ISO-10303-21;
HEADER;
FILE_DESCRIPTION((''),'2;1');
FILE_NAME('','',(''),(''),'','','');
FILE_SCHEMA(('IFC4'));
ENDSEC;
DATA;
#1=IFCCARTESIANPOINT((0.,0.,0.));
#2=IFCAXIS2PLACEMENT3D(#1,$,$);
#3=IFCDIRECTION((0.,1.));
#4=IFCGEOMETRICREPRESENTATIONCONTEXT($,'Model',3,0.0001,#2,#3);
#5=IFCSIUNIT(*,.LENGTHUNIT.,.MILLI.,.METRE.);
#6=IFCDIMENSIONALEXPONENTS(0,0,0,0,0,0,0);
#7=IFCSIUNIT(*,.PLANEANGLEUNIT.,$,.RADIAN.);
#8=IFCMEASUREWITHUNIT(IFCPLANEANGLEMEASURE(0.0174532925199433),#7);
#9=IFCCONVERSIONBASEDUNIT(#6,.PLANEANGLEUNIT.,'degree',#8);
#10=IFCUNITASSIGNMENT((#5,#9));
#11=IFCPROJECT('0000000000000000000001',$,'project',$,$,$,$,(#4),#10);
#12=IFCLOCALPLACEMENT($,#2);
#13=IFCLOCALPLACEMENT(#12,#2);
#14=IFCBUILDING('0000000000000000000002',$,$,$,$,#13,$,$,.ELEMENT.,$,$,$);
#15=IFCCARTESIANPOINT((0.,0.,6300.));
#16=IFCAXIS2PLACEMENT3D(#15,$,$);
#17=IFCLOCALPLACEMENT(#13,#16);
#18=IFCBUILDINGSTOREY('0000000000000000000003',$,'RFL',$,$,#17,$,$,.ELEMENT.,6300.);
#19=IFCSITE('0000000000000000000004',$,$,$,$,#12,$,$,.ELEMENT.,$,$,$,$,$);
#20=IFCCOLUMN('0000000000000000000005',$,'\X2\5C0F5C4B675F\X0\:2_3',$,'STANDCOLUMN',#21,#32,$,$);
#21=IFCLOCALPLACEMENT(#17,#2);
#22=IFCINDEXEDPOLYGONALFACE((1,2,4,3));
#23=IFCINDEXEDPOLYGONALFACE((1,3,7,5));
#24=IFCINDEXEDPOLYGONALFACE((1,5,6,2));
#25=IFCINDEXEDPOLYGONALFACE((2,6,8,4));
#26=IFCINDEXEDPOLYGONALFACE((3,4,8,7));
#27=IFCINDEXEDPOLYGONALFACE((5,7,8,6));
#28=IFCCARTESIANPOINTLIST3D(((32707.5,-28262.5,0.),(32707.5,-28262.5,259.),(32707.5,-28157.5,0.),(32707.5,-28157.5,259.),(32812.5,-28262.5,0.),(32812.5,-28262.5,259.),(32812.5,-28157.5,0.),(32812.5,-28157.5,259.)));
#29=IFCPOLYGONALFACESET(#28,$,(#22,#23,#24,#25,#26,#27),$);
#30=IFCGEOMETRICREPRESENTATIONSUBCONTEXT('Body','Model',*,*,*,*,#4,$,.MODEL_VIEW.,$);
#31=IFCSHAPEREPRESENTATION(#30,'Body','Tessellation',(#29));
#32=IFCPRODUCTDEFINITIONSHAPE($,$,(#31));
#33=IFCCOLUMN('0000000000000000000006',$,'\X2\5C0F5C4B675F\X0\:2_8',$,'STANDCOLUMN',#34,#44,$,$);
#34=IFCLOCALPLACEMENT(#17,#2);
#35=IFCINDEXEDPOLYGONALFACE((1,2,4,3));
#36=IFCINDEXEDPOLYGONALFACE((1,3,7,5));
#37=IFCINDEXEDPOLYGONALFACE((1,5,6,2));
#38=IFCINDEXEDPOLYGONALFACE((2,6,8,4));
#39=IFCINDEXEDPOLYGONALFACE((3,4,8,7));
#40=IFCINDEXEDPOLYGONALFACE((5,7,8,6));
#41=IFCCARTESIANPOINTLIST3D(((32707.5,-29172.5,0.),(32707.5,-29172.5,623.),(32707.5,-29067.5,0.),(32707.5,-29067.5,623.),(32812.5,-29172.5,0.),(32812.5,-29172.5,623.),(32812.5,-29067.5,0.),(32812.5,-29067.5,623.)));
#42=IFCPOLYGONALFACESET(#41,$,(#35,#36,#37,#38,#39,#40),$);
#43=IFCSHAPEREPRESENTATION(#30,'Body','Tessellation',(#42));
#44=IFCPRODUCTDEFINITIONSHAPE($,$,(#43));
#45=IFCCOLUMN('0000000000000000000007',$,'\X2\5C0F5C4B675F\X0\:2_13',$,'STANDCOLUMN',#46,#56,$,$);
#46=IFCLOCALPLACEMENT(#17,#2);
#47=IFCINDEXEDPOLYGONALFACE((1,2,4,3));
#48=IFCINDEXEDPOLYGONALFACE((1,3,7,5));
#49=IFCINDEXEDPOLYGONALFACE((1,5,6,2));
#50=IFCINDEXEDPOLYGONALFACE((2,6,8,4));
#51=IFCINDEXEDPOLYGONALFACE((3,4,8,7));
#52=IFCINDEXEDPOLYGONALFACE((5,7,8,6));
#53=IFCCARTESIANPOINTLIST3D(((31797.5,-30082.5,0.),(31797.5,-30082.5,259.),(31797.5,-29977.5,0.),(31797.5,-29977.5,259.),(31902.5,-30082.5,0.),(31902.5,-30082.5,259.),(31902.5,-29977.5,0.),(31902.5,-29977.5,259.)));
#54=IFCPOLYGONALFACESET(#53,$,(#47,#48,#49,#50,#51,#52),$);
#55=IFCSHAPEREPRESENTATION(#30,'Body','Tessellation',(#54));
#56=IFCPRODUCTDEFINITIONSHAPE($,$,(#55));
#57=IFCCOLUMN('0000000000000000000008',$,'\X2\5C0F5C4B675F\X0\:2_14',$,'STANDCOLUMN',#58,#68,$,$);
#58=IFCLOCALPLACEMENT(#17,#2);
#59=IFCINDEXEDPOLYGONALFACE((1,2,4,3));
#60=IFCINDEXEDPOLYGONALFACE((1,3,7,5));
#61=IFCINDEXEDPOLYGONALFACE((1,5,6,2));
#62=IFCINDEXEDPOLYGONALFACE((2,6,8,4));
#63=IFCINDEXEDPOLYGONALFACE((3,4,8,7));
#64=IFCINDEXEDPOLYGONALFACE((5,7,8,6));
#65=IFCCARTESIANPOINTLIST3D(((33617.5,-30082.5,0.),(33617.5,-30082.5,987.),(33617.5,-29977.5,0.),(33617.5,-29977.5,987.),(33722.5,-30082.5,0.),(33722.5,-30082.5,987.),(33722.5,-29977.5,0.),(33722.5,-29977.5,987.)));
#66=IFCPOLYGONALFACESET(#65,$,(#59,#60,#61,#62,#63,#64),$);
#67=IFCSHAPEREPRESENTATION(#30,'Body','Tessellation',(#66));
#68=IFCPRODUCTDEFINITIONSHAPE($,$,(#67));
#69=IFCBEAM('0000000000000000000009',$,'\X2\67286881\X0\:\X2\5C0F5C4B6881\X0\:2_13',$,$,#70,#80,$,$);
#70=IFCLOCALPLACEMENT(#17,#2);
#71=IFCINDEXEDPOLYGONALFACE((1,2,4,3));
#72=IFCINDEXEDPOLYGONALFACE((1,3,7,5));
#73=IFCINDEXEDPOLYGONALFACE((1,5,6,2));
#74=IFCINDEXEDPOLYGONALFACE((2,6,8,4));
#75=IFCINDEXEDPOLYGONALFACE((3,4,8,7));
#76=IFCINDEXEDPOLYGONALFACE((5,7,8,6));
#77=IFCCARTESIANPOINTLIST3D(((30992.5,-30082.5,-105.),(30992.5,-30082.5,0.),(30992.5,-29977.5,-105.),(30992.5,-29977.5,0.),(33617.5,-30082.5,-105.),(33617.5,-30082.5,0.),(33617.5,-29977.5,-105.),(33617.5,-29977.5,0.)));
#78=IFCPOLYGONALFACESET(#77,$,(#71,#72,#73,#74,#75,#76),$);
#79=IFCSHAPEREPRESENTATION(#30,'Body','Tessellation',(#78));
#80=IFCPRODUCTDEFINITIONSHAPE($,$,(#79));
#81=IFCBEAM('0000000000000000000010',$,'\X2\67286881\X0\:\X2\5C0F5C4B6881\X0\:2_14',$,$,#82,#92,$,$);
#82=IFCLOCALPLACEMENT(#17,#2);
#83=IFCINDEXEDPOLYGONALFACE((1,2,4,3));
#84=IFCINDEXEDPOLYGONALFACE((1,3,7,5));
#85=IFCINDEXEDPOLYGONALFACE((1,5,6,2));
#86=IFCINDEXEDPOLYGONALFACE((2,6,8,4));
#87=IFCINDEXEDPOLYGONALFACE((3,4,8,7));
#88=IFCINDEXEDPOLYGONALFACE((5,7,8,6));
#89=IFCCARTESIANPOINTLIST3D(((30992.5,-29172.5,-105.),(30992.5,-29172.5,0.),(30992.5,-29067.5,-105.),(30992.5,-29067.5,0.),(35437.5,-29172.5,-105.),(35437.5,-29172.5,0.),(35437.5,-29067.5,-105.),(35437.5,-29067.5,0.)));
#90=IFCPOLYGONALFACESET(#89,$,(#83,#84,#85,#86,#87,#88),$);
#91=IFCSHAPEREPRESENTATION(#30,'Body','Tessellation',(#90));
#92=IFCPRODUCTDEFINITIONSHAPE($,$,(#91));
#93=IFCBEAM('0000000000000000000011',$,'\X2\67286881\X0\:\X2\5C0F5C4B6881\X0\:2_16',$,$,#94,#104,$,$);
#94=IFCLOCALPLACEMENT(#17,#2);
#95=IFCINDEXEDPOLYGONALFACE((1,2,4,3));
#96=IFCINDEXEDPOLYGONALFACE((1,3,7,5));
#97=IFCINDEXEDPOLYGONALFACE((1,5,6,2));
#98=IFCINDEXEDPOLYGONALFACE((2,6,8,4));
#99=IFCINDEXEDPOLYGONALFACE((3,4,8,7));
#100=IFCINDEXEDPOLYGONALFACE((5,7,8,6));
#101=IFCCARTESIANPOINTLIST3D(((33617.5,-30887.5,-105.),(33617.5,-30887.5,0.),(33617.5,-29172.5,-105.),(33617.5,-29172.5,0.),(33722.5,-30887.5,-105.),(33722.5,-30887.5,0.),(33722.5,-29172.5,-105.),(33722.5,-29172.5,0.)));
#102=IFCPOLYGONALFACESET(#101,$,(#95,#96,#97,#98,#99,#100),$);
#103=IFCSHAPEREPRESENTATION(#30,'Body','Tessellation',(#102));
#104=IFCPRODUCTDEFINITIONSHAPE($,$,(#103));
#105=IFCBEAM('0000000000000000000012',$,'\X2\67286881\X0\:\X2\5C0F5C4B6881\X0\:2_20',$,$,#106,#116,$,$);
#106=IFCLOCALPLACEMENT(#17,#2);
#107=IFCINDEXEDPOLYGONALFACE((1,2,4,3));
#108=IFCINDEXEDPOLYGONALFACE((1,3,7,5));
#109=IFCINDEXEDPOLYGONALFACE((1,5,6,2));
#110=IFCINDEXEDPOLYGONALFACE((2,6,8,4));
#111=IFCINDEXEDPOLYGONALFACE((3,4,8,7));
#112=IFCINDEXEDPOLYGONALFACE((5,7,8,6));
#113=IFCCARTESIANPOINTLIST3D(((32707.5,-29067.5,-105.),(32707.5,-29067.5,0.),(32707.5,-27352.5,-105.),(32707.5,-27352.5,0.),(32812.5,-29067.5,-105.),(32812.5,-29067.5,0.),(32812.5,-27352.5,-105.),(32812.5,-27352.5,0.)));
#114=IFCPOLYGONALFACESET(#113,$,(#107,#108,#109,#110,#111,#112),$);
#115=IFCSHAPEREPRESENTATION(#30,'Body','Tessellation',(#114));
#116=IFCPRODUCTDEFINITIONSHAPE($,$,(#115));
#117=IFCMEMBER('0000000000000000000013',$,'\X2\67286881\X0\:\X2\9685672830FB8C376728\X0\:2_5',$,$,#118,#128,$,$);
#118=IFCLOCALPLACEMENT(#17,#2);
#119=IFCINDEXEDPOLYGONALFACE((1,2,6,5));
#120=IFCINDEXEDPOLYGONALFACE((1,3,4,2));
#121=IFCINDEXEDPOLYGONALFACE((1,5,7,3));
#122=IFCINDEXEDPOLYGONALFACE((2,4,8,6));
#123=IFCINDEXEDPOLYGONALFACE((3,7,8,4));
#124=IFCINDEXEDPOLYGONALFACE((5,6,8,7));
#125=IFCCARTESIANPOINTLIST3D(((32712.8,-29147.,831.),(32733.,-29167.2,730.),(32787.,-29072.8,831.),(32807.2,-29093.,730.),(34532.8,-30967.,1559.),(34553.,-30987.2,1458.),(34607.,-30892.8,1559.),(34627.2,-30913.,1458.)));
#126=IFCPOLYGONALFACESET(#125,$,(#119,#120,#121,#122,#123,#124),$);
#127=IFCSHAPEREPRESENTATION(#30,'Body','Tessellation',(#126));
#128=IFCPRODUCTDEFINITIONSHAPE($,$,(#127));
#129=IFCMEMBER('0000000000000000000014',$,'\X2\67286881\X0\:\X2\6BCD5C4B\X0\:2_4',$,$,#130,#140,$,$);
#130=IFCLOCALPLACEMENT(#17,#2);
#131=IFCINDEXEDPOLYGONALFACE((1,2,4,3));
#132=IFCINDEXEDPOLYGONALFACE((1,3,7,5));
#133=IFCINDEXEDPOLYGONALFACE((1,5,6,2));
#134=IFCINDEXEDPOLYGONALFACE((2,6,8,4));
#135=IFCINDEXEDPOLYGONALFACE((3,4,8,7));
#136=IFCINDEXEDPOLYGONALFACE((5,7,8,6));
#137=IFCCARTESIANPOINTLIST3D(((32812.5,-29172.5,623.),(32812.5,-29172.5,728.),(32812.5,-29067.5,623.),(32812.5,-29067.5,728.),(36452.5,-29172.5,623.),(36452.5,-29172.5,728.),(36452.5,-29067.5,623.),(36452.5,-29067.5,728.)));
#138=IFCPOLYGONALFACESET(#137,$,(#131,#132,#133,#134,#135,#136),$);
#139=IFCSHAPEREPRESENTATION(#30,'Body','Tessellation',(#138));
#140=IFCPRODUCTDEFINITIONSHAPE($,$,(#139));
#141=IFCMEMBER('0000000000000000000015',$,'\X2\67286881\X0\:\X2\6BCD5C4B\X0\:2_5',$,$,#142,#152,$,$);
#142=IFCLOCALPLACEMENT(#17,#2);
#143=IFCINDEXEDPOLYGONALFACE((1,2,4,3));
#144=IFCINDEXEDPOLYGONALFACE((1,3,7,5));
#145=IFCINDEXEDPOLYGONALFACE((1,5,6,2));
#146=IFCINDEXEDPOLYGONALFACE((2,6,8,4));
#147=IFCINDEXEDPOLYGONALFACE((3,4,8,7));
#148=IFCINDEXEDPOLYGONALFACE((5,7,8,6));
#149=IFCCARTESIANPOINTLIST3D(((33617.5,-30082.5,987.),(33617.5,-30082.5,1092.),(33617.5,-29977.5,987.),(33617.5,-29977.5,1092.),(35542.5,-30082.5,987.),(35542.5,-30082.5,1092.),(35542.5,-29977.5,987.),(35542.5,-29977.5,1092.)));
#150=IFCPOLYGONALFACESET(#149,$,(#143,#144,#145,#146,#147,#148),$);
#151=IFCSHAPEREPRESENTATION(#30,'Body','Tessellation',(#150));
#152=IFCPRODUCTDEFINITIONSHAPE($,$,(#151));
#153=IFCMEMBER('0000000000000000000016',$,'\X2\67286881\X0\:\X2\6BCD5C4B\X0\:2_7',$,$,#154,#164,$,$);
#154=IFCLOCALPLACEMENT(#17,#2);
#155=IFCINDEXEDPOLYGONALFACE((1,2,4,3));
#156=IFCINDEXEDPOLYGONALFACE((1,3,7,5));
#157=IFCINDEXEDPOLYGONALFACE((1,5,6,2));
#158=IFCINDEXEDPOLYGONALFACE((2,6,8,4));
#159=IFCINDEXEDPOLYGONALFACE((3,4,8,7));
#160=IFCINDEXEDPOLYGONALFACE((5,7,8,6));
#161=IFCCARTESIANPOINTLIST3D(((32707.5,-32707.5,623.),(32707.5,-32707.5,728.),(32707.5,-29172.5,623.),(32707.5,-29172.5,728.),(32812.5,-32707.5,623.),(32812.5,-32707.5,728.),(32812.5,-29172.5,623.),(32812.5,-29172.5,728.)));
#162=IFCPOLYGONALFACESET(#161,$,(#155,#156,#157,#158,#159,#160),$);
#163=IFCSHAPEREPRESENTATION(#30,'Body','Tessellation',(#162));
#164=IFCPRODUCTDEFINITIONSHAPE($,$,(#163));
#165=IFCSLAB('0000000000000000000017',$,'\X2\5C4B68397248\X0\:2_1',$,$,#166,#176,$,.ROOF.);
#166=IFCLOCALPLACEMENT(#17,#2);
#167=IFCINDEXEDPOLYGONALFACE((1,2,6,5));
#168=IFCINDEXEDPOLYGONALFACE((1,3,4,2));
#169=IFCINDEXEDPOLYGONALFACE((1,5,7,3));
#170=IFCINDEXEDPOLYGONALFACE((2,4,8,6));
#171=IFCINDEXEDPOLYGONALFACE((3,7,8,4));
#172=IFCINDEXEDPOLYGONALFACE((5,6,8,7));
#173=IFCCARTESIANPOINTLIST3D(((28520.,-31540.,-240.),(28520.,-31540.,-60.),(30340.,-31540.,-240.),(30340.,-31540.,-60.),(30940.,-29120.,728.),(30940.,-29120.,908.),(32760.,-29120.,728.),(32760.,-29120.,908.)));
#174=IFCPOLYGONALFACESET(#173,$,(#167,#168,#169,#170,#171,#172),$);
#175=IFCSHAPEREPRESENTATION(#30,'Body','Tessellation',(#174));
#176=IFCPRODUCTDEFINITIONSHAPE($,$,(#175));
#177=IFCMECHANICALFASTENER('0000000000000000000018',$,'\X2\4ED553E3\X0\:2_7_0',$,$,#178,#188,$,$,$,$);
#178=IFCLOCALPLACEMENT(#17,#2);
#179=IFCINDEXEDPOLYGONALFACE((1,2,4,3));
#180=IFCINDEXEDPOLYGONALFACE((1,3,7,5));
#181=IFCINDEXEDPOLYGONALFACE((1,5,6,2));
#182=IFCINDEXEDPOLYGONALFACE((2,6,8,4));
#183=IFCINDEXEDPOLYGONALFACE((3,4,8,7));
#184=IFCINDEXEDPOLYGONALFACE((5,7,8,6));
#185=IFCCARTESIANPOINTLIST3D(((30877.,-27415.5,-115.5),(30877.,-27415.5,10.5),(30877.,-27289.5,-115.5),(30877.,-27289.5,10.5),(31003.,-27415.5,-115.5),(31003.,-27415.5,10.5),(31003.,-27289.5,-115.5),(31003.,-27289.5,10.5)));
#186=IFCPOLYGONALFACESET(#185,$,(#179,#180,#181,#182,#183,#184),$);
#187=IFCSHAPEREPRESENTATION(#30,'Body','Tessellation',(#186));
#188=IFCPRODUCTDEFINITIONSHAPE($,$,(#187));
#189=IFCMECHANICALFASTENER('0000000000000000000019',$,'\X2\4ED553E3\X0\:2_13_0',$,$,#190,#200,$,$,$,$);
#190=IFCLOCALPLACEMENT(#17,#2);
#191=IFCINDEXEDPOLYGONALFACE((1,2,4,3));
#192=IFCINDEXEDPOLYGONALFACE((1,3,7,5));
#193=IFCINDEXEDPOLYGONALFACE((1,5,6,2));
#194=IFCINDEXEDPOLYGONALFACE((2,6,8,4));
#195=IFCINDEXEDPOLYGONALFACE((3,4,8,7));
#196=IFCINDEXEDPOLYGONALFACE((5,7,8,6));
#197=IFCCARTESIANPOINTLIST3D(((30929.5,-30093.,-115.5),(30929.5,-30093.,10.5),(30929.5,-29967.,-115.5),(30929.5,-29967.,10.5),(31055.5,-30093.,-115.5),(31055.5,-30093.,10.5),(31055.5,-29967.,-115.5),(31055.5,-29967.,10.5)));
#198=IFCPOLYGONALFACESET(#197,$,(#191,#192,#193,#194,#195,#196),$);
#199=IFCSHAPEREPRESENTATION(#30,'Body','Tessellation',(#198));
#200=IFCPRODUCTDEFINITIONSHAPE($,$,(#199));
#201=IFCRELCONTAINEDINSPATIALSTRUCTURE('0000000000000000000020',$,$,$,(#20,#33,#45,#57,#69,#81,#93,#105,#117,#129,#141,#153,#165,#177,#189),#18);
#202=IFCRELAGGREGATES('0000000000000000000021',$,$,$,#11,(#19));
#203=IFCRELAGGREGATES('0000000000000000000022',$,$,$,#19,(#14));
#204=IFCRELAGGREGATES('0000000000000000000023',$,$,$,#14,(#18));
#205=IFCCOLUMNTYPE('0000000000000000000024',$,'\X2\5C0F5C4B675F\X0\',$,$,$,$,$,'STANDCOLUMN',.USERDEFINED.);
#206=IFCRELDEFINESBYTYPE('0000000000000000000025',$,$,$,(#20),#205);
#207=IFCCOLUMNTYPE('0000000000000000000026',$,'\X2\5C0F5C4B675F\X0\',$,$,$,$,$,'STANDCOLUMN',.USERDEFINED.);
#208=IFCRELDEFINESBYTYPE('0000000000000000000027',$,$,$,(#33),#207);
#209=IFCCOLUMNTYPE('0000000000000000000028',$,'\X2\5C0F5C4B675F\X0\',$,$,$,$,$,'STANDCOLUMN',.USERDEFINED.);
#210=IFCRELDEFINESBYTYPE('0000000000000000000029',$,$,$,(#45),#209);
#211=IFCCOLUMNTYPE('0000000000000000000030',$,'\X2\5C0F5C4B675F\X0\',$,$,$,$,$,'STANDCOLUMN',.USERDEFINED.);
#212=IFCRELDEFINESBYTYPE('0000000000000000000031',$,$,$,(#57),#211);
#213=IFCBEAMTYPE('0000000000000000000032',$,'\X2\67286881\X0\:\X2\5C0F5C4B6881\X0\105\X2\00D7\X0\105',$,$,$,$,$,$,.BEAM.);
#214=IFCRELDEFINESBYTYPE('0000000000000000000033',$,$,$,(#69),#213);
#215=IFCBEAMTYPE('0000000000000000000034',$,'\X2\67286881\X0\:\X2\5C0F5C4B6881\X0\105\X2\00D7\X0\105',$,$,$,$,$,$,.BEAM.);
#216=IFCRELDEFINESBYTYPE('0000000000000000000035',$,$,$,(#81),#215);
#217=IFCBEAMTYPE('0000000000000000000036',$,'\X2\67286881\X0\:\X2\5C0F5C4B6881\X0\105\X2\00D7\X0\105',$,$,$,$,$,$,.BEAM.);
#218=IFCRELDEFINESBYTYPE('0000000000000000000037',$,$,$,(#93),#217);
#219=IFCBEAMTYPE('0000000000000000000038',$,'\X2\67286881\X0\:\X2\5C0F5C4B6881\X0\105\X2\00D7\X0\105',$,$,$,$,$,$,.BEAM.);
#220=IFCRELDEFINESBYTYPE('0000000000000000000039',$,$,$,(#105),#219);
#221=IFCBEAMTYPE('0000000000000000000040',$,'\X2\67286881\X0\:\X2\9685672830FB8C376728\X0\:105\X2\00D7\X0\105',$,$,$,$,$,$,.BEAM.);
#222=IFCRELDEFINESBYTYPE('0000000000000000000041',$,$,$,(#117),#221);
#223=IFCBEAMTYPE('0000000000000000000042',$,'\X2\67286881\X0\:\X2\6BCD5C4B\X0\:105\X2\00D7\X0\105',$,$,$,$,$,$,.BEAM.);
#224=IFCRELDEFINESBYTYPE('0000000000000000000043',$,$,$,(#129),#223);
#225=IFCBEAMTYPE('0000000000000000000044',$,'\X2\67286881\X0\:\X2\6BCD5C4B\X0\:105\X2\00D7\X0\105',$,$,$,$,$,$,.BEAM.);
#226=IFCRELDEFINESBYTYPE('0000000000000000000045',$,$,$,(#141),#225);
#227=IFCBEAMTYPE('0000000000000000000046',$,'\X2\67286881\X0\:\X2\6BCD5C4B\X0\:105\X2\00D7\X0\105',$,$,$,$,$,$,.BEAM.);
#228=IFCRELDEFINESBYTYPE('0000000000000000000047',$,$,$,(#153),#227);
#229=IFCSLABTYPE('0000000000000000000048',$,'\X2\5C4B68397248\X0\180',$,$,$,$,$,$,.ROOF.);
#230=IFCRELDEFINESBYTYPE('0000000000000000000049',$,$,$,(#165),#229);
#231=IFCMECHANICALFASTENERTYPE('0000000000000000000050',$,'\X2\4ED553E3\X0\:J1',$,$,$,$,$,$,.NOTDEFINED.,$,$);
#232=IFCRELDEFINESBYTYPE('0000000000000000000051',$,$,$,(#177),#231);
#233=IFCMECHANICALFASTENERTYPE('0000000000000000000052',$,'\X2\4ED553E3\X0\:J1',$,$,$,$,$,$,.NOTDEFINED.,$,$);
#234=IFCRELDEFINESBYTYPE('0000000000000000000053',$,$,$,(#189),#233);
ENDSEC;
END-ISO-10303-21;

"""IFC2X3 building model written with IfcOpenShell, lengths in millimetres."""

from ifc_helpers import new_model, entity, si_unit, converted_unit, direction, frame, origin, origin_with_axes, origin_2d, place, context, subcontext, project, spatial, polyline, rectangle, outline, extrude, type_object, element, save


model = new_model("IFC2X3")

# Units and contexts
model_context = context("Model", 3, precision=0.0001, world=origin(), true_north=direction((0.0, 1.0)))
body_context = subcontext(model_context, "Body", "Model", "MODEL_VIEW")
ifc_project = project(units=[si_unit("LENGTHUNIT", "METRE", prefix="MILLI"), converted_unit("PLANEANGLEUNIT", "degree", entity("IfcPlaneAngleMeasure", 0.0174532925199433), si_unit("PLANEANGLEUNIT", "RADIAN"), dimensions=[0, 0, 0, 0, 0, 0, 0])], contexts=[model_context])

# Site, building, storey
site_placement = place(None, origin())
site = spatial("IfcSite", under=ifc_project, at=site_placement, CompositionType="ELEMENT")
building_placement = place(site_placement, origin())
building = spatial("IfcBuilding", under=site, at=building_placement, CompositionType="ELEMENT")
storey_placement = place(building_placement, frame((0.0, 0.0, 6300.0)))
storey = spatial("IfcBuildingStorey", under=building, at=storey_placement, Name="RFL", CompositionType="ELEMENT", Elevation=6300.0)

# Columns
column_type_1 = type_object("IfcColumnType", Name="小屋束", ElementType="STANDCOLUMN", PredefinedType="USERDEFINED")
column_1_placement = place(storey_placement, frame((32760.0, -28210.0, 0.0)))
element("IfcColumn", 1, at=column_1_placement, inside=storey, type_object=column_type_1, Name="小屋束:2_3", ObjectType="STANDCOLUMN", context=body_context, shape_type="SweptSolid", body=[
    extrude(rectangle(XDim=105.0, YDim=105.0, at=origin_2d()), origin_with_axes(), (0.0, 0.0, 1.0), 259.0),
])
column_type_2 = type_object("IfcColumnType", Name="小屋束", ElementType="STANDCOLUMN", PredefinedType="USERDEFINED")
column_2_placement = place(storey_placement, frame((32760.0, -29120.0, 0.0)))
element("IfcColumn", 2, at=column_2_placement, inside=storey, type_object=column_type_2, Name="小屋束:2_8", ObjectType="STANDCOLUMN", context=body_context, shape_type="SweptSolid", body=[
    extrude(rectangle(XDim=105.0, YDim=105.0, at=origin_2d()), origin_with_axes(), (0.0, 0.0, 1.0), 623.0),
])
column_type_3 = type_object("IfcColumnType", Name="小屋束", ElementType="STANDCOLUMN", PredefinedType="USERDEFINED")
column_3_placement = place(storey_placement, frame((31850.0, -30030.0, 0.0)))
element("IfcColumn", 3, at=column_3_placement, inside=storey, type_object=column_type_3, Name="小屋束:2_13", ObjectType="STANDCOLUMN", context=body_context, shape_type="SweptSolid", body=[
    extrude(rectangle(XDim=105.0, YDim=105.0, at=origin_2d()), origin_with_axes(), (0.0, 0.0, 1.0), 259.0),
])
column_type_4 = type_object("IfcColumnType", Name="小屋束", ElementType="STANDCOLUMN", PredefinedType="USERDEFINED")
column_4_placement = place(storey_placement, frame((33670.0, -30030.0, 0.0)))
element("IfcColumn", 4, at=column_4_placement, inside=storey, type_object=column_type_4, Name="小屋束:2_14", ObjectType="STANDCOLUMN", context=body_context, shape_type="SweptSolid", body=[
    extrude(rectangle(XDim=105.0, YDim=105.0, at=origin_2d()), origin_with_axes(), (0.0, 0.0, 1.0), 987.0),
])

# Beams
beam_type_1 = type_object("IfcBeamType", Name="木梁:小屋梁105×105", PredefinedType="BEAM")
beam_1_placement = place(storey_placement, frame((30992.5, -30030.0, -52.5), z_axis=(1.0, 0.0, 0.0), x_axis=(0.0, 1.0, 0.0)))
element("IfcBeam", 5, at=beam_1_placement, inside=storey, type_object=beam_type_1, Name="木梁:小屋梁:2_13", context=body_context, shape_type="SweptSolid", body=[
    extrude(rectangle(XDim=105.0, YDim=105.0, at=origin_2d()), origin_with_axes(), (0.0, 0.0, 1.0), 2625.0),
])
beam_type_2 = type_object("IfcBeamType", Name="木梁:小屋梁105×105", PredefinedType="BEAM")
beam_2_placement = place(storey_placement, frame((30992.5, -29120.0, -52.5), z_axis=(1.0, 0.0, 0.0), x_axis=(0.0, 1.0, 0.0)))
element("IfcBeam", 6, at=beam_2_placement, inside=storey, type_object=beam_type_2, Name="木梁:小屋梁:2_14", context=body_context, shape_type="SweptSolid", body=[
    extrude(rectangle(XDim=105.0, YDim=105.0, at=origin_2d()), origin_with_axes(), (0.0, 0.0, 1.0), 4445.0),
])
beam_type_3 = type_object("IfcBeamType", Name="木梁:小屋梁105×105", PredefinedType="BEAM")
beam_3_placement = place(storey_placement, frame((33670.0, -29172.5, -52.5), z_axis=(0.0, -1.0, 0.0), x_axis=(1.0, 0.0, 0.0)))
element("IfcBeam", 7, at=beam_3_placement, inside=storey, type_object=beam_type_3, Name="木梁:小屋梁:2_16", context=body_context, shape_type="SweptSolid", body=[
    extrude(rectangle(XDim=105.0, YDim=105.0, at=origin_2d()), origin_with_axes(), (0.0, 0.0, 1.0), 1715.0),
])
beam_type_4 = type_object("IfcBeamType", Name="木梁:小屋梁105×105", PredefinedType="BEAM")
beam_4_placement = place(storey_placement, frame((32760.0, -27352.5, -52.5), z_axis=(0.0, -1.0, 0.0), x_axis=(1.0, 0.0, 0.0)))
element("IfcBeam", 8, at=beam_4_placement, inside=storey, type_object=beam_type_4, Name="木梁:小屋梁:2_20", context=body_context, shape_type="SweptSolid", body=[
    extrude(rectangle(XDim=105.0, YDim=105.0, at=origin_2d()), origin_with_axes(), (0.0, 0.0, 1.0), 1715.0),
])

# Members
beam_type_5 = type_object("IfcBeamType", Name="木梁:隅木・谷木:105×105", PredefinedType="BEAM")
member_1_placement = place(storey_placement, frame((32760.0, -29120.0, 780.5), z_axis=(0.680414, -0.680414, 0.272166), x_axis=(-0.707107, -0.707107, 0.0)))
element("IfcMember", 9, at=member_1_placement, inside=storey, type_object=beam_type_5, Name="木梁:隅木・谷木:2_5", context=body_context, shape_type="SweptSolid", body=[
    extrude(rectangle(XDim=105.0, YDim=105.0, at=origin_2d()), origin_with_axes(), (0.0, 0.0, 1.0), 2674.8),
])
beam_type_6 = type_object("IfcBeamType", Name="木梁:母屋:105×105", PredefinedType="BEAM")
member_2_placement = place(storey_placement, frame((32812.5, -29120.0, 675.5), z_axis=(1.0, 0.0, 0.0), x_axis=(0.0, -1.0, 0.0)))
element("IfcMember", 10, at=member_2_placement, inside=storey, type_object=beam_type_6, Name="木梁:母屋:2_4", context=body_context, shape_type="SweptSolid", body=[
    extrude(rectangle(XDim=105.0, YDim=105.0, at=origin_2d()), origin_with_axes(), (0.0, 0.0, 1.0), 3640.0),
])
beam_type_7 = type_object("IfcBeamType", Name="木梁:母屋:105×105", PredefinedType="BEAM")
member_3_placement = place(storey_placement, frame((33617.5, -30030.0, 1039.5), z_axis=(1.0, 0.0, 0.0), x_axis=(0.0, -1.0, 0.0)))
element("IfcMember", 11, at=member_3_placement, inside=storey, type_object=beam_type_7, Name="木梁:母屋:2_5", context=body_context, shape_type="SweptSolid", body=[
    extrude(rectangle(XDim=105.0, YDim=105.0, at=origin_2d()), origin_with_axes(), (0.0, 0.0, 1.0), 1925.0),
])
beam_type_8 = type_object("IfcBeamType", Name="木梁:母屋:105×105", PredefinedType="BEAM")
member_4_placement = place(storey_placement, frame((32760.0, -29172.5, 675.5), z_axis=(0.0, -1.0, 0.0), x_axis=(-1.0, 0.0, 0.0)))
element("IfcMember", 12, at=member_4_placement, inside=storey, type_object=beam_type_8, Name="木梁:母屋:2_7", context=body_context, shape_type="SweptSolid", body=[
    extrude(rectangle(XDim=105.0, YDim=105.0, at=origin_2d()), origin_with_axes(), (0.0, 0.0, 1.0), 3535.0),
])

# Slab
slab_type = type_object("IfcSlabType", Name="屋根版180", PredefinedType="ROOF")
slab_placement = place(storey_placement, frame((32760.0, -29120.0, 728.0), z_axis=(0.0, 0.371391, -0.928477), x_axis=(-0.680414, -0.680414, -0.272166)))
element("IfcSlab", 13, at=slab_placement, inside=storey, type_object=slab_type, Name="屋根版:2_1", PredefinedType="ROOF", context=body_context, shape_type="SweptSolid", body=[
    extrude(outline(polyline([(0.0, 0.0, 0.0), (3556.7, 0.0, 0.0), (4795.0, 1333.7, 0.0), (1238.4, 1333.7, 0.0), (0.0, 0.0, 0.0)])), origin_with_axes(), (-0.272166, 0.252699, -0.928477), 180.0),
])

# Mechanical fasteners
mechanical_fastener_type_1 = type_object("IfcMechanicalFastenerType", Name="仕口:J1")
mechanical_fastener_1_placement = place(storey_placement, frame((30940.0, -27352.5, -115.5)))
element("IfcMechanicalFastener", 14, at=mechanical_fastener_1_placement, inside=storey, type_object=mechanical_fastener_type_1, Name="仕口:2_7_0", context=body_context, shape_type="SweptSolid", body=[
    extrude(rectangle(XDim=126.0, YDim=126.0, at=origin_2d()), origin_with_axes(), (0.0, 0.0, 1.0), 126.0),
])
mechanical_fastener_type_2 = type_object("IfcMechanicalFastenerType", Name="仕口:J1")
mechanical_fastener_2_placement = place(storey_placement, frame((30992.5, -30030.0, -115.5)))
element("IfcMechanicalFastener", 15, at=mechanical_fastener_2_placement, inside=storey, type_object=mechanical_fastener_type_2, Name="仕口:2_13_0", context=body_context, shape_type="SweptSolid", body=[
    extrude(rectangle(XDim=126.0, YDim=126.0, at=origin_2d()), origin_with_axes(), (0.0, 0.0, 1.0), 126.0),
])

save(model, "model.ifc")
